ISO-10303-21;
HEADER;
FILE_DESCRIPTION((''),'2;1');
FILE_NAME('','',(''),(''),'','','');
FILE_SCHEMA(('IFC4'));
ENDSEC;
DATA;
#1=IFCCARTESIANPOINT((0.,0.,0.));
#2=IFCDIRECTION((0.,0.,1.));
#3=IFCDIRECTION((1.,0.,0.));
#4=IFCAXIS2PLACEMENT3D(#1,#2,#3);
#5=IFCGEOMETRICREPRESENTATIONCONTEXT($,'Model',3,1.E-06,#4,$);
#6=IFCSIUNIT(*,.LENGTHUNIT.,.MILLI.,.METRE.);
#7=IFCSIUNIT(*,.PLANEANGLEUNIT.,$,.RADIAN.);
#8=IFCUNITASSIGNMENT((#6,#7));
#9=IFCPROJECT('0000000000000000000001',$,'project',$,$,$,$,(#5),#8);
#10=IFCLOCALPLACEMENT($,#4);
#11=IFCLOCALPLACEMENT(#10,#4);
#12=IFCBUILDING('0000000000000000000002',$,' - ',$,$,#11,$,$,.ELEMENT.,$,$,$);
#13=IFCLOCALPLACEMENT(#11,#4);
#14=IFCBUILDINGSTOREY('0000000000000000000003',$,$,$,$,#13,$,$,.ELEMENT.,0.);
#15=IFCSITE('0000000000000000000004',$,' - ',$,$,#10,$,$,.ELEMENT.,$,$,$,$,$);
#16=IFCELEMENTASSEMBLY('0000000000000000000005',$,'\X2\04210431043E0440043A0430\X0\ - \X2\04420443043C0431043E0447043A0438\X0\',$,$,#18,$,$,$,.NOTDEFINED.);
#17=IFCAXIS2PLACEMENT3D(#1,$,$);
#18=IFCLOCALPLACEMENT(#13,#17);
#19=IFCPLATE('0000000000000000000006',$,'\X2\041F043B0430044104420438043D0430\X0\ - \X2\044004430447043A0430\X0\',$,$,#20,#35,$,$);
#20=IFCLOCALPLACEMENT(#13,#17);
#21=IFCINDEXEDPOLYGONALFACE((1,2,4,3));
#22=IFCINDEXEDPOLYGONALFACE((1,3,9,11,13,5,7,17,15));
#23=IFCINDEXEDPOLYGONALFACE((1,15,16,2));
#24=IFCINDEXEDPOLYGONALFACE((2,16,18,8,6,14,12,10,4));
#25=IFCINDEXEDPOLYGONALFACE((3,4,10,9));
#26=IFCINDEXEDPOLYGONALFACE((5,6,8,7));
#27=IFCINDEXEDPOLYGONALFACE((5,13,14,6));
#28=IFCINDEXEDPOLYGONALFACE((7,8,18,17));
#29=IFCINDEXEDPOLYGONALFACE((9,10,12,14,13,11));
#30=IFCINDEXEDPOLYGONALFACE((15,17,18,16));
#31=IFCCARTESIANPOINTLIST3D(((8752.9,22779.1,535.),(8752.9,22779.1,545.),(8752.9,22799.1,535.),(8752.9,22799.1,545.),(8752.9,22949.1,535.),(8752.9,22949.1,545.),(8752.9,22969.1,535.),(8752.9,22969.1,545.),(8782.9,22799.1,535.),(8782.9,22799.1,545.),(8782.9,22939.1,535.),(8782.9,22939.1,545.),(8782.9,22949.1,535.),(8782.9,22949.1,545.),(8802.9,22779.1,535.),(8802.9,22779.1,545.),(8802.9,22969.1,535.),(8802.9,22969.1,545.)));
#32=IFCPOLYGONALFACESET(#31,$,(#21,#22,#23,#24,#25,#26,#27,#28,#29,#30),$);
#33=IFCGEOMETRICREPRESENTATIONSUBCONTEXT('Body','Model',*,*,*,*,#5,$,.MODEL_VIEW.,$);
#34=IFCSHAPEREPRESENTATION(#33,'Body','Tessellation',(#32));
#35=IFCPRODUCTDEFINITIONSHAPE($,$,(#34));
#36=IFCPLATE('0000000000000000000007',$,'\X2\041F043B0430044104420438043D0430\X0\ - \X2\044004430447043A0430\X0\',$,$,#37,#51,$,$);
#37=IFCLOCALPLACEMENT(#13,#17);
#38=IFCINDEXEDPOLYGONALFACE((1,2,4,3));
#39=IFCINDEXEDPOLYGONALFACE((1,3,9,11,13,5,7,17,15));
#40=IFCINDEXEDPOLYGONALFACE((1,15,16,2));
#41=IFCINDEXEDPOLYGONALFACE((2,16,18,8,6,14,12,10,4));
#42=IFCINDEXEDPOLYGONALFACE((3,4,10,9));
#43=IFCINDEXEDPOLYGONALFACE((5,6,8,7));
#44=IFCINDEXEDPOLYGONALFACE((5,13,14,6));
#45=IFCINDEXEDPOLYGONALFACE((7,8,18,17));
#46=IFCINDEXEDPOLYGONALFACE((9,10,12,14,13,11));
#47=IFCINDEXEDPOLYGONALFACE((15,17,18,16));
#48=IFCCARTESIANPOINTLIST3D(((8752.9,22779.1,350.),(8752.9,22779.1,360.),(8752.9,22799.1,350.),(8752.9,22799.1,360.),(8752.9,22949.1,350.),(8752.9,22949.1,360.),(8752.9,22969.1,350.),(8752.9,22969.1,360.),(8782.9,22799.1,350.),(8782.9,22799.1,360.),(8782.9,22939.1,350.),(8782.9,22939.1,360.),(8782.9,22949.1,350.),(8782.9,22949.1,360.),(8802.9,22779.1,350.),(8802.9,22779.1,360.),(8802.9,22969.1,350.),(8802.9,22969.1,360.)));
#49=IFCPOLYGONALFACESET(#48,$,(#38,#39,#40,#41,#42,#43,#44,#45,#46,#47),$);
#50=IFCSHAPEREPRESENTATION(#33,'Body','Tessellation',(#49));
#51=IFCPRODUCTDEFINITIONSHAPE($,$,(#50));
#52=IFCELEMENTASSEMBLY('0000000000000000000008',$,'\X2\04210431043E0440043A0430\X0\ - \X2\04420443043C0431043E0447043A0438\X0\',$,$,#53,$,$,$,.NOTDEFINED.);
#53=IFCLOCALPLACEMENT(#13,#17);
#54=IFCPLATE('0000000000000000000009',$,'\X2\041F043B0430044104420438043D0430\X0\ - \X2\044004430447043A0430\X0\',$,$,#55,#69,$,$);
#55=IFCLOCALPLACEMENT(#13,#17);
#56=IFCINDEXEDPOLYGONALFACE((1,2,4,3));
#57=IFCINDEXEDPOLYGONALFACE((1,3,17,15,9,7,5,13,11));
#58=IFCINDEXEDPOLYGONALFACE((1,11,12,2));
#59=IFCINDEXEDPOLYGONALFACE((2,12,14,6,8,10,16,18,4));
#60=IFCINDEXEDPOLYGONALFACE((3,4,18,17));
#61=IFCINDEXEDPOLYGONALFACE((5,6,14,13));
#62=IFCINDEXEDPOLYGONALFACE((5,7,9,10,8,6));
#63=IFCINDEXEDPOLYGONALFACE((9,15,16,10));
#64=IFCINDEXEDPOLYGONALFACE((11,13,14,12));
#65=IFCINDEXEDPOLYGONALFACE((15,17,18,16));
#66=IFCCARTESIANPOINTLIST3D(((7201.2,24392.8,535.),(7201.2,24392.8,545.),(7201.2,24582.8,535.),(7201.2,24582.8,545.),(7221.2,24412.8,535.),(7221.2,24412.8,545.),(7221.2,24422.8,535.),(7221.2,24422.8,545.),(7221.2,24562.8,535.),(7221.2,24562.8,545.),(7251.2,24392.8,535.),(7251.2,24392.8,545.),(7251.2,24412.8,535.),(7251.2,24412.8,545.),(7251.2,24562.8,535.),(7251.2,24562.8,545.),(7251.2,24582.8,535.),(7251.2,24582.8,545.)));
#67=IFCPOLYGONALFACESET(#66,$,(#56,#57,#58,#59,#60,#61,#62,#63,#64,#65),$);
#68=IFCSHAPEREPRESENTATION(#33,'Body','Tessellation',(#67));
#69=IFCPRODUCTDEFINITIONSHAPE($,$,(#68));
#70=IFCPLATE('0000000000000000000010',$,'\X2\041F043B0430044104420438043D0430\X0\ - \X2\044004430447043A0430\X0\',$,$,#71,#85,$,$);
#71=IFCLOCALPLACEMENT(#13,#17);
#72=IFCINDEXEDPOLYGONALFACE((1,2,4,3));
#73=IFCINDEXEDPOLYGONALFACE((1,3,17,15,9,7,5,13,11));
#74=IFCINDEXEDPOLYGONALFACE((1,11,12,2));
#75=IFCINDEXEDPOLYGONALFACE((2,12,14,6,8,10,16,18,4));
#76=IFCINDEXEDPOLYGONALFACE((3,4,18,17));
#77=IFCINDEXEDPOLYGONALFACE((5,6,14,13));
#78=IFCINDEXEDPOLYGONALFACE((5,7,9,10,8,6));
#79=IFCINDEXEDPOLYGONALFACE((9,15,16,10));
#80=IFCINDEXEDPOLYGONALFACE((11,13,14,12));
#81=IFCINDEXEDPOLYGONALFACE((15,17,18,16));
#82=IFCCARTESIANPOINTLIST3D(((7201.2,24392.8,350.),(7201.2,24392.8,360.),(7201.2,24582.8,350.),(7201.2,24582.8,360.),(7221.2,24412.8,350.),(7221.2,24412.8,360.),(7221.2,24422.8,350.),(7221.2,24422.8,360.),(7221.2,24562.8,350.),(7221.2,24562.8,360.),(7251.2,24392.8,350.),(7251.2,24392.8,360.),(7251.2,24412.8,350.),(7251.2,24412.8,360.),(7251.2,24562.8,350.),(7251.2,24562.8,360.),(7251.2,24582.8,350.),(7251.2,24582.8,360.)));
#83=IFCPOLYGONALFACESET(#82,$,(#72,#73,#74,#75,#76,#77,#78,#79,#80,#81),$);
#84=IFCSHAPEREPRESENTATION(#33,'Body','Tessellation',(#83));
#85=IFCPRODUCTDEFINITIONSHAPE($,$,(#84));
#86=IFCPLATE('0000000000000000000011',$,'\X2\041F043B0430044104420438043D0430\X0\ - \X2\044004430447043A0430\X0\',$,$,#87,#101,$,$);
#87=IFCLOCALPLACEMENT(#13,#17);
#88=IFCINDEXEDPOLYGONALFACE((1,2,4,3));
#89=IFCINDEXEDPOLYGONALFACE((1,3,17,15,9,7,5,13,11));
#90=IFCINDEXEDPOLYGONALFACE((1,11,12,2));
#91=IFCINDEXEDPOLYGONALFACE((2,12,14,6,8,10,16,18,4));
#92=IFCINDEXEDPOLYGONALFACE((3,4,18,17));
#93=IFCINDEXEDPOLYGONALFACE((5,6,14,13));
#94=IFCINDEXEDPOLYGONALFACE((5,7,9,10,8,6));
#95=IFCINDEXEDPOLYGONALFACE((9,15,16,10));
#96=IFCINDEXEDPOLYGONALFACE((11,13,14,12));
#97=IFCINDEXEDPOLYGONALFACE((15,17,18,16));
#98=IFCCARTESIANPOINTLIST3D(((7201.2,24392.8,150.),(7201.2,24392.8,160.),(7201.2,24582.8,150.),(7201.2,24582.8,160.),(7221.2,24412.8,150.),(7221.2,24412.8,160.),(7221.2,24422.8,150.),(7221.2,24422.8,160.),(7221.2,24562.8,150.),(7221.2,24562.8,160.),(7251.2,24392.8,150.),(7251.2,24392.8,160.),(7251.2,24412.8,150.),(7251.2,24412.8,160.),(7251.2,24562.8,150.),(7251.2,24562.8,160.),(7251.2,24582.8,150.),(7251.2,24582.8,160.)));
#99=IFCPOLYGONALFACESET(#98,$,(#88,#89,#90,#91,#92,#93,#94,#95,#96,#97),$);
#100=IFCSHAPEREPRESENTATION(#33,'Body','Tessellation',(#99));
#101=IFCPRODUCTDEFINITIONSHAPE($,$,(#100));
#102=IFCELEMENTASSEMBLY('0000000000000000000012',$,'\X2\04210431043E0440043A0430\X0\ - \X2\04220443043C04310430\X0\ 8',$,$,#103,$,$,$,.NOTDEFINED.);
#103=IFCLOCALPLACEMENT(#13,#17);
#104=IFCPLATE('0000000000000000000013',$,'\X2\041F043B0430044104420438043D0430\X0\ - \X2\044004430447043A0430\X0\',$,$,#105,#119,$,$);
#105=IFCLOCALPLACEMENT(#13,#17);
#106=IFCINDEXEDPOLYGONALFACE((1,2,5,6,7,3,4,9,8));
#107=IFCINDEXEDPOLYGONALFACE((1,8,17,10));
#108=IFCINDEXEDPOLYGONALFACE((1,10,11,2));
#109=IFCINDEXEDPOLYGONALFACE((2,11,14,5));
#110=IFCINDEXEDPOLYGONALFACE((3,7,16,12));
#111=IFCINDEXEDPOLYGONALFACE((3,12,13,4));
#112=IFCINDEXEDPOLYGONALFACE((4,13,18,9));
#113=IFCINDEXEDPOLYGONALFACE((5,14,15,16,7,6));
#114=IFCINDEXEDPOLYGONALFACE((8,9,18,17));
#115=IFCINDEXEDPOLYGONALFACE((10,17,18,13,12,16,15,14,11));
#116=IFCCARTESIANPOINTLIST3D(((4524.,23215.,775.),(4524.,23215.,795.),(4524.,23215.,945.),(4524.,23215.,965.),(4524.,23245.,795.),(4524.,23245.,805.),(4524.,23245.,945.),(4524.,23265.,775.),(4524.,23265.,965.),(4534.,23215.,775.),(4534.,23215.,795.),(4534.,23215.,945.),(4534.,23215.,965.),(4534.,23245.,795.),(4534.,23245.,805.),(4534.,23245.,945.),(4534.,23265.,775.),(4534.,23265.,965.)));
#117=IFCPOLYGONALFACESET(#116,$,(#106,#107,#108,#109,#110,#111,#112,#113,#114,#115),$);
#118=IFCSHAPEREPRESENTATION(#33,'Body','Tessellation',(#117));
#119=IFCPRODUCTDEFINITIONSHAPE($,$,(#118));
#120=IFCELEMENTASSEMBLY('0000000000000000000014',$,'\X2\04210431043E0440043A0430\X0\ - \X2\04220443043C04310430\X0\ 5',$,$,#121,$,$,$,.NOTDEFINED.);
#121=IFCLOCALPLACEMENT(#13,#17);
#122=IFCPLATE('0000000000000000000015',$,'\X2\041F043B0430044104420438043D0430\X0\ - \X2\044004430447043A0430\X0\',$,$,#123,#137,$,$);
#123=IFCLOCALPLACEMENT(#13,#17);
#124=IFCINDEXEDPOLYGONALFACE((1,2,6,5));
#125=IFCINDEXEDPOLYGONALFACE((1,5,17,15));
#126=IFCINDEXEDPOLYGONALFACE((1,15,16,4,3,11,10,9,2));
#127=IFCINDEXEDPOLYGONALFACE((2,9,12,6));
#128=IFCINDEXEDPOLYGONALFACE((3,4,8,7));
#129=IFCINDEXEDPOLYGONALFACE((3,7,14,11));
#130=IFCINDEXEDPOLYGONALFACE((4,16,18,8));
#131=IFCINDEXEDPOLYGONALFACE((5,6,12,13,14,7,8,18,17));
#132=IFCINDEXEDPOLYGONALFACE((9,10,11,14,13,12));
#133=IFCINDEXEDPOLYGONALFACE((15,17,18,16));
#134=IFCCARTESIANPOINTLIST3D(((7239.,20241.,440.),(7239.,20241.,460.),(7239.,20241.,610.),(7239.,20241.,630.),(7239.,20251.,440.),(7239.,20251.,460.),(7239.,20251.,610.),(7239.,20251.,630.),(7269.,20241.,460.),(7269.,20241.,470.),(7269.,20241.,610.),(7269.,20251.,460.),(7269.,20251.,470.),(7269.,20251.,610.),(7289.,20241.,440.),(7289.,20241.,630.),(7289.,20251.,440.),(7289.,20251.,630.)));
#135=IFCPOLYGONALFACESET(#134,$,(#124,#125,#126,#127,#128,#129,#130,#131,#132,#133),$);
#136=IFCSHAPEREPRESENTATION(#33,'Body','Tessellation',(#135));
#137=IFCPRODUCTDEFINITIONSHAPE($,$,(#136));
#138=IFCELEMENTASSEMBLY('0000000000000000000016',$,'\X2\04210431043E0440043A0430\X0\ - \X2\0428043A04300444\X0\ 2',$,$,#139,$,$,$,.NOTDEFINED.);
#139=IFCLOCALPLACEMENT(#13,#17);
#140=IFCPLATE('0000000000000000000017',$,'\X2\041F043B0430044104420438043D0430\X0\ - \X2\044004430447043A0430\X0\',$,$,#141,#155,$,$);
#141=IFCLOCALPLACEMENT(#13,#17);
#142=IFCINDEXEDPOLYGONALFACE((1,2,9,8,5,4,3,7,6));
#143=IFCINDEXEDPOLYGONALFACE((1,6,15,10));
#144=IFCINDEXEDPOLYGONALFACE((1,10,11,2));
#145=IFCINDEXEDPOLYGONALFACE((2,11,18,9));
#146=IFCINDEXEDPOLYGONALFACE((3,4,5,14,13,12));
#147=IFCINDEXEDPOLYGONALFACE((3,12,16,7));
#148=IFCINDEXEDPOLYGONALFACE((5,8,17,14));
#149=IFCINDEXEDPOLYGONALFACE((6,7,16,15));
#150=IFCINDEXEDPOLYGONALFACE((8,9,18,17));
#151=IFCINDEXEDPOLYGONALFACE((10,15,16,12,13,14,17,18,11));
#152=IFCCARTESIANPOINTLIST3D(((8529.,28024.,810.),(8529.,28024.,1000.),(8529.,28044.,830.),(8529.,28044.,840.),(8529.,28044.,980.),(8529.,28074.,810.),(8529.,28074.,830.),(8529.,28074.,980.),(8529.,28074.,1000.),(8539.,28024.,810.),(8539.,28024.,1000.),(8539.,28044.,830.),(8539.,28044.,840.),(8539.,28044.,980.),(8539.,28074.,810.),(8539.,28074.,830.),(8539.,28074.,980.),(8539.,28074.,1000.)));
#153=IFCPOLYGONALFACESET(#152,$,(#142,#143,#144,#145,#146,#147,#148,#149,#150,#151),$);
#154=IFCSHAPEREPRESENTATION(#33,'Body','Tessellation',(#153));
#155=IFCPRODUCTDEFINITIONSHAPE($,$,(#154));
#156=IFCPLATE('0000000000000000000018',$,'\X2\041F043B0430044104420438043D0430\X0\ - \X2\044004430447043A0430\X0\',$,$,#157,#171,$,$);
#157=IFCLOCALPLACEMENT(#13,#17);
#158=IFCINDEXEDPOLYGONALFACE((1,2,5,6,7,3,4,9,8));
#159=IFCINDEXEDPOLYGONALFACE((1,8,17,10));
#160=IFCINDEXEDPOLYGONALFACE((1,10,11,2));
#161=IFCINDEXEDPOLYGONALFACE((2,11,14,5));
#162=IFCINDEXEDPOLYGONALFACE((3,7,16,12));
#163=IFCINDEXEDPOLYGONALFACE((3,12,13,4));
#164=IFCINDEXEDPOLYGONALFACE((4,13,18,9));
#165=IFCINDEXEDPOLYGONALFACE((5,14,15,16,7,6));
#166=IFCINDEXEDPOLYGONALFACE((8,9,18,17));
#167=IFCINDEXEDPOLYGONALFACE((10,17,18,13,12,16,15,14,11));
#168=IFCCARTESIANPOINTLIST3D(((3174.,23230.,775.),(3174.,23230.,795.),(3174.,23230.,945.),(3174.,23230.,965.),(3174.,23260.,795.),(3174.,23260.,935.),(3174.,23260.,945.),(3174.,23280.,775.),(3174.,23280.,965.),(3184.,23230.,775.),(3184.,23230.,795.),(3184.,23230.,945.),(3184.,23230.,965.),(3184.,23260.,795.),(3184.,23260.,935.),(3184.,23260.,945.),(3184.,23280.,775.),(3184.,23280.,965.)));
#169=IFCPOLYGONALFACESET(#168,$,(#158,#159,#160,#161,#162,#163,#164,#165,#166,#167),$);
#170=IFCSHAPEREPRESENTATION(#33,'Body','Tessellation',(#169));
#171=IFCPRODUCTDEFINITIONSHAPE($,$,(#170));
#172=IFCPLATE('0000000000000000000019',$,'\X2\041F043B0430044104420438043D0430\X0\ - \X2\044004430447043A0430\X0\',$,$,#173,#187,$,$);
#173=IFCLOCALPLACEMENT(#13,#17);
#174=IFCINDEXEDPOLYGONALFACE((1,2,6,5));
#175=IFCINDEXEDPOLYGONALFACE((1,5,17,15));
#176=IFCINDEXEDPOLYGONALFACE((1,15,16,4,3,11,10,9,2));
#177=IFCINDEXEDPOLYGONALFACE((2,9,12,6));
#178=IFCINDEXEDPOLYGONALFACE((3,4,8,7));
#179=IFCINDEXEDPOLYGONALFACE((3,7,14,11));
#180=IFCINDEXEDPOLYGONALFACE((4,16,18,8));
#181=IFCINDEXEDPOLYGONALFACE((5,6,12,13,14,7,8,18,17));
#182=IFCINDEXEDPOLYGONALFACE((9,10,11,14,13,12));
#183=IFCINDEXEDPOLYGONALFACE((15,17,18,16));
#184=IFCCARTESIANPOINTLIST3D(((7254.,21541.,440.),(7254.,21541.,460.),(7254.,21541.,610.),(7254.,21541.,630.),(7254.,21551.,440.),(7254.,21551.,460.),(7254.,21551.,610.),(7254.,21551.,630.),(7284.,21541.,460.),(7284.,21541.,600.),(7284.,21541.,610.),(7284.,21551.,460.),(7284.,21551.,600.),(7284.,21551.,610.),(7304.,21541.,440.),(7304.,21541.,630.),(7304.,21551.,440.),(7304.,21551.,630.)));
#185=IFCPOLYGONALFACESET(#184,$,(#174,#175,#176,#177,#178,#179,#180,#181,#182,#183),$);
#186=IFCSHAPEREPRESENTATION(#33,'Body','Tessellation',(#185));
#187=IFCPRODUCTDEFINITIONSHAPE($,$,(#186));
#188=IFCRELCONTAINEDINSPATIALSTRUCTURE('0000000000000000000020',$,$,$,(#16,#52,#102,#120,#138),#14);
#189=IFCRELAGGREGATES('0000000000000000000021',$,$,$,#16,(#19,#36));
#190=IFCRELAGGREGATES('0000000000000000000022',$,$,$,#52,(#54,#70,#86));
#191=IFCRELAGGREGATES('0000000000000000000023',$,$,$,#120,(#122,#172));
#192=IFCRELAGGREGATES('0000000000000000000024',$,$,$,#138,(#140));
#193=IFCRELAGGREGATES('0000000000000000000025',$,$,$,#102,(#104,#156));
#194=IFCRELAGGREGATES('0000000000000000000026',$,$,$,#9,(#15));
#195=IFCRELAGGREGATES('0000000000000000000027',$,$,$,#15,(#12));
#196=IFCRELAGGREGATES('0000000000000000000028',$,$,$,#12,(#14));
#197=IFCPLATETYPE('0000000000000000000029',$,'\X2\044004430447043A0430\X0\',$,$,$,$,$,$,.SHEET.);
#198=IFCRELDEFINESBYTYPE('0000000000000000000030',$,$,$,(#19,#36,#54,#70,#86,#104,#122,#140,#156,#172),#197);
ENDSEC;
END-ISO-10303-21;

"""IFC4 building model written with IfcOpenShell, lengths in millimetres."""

from ifc_helpers import new_model, si_unit, frame, origin_with_axes, place, context, subcontext, project, spatial, line, indexed_curve, outline, extrude, source, transform, mapped, type_object, element, aggregate, save


model = new_model("IFC4")

# Units and contexts
model_context = context("Model", 3, precision=1e-06, world=origin_with_axes())
body_context = subcontext(model_context, "Body", "Model", "MODEL_VIEW")
ifc_project = project(units=[si_unit("LENGTHUNIT", "METRE", prefix="MILLI"), si_unit("PLANEANGLEUNIT", "RADIAN")], contexts=[model_context])

# Site, building, storey
site_placement = place(None, origin_with_axes())
site = spatial("IfcSite", under=ifc_project, at=site_placement, Name=" - ", CompositionType="ELEMENT")
building_placement = place(site_placement, origin_with_axes())
building = spatial("IfcBuilding", under=site, at=building_placement, Name=" - ", CompositionType="ELEMENT")
storey_placement = place(building_placement, origin_with_axes())
storey = spatial("IfcBuildingStorey", under=building, at=storey_placement, CompositionType="ELEMENT", Elevation=0.0)

# Element assemblies, plates
plate_type_1 = type_object("IfcPlateType", Name="ручка", PredefinedType="SHEET")
shared_shape_1 = source(origin_with_axes(), body_context, "Body", "SweptSolid", [
    extrude(outline(indexed_curve([(-95.0, -25.0), (-75.0, -25.0), (-75.0, 5.0), (-65.0, 5.0), (75.0, 5.0), (75.0, -25.0), (95.0, -25.0), (95.0, 25.0), (-95.0, 25.0)], segments=[line(1, 2), line(2, 3), line(3, 4), line(4, 5), line(5, 6), line(6, 7), line(7, 8), line(8, 9), line(9, 1)])), origin_with_axes(), (0.0, 0.0, 1.0), 10.0),
])
assembly_1_placement = place(storey_placement, frame((8752.9, 22674.1, 0.0), z_axis=(0.0, 0.0, 1.0), x_axis=(0.0, 1.0, 0.0)))
assembly_1 = element("IfcElementAssembly", 1, at=assembly_1_placement, inside=storey, Name="Сборка - тумбочки", PredefinedType="NOTDEFINED")
plate_1_placement = place(assembly_1_placement, frame((200.0, -25.0, 535.0), z_axis=(0.0, 0.0, 1.0), x_axis=(-1.0, 0.0, 0.0)))
plate_1 = element("IfcPlate", 2, at=plate_1_placement, type_object=plate_type_1, Name="Пластина - ручка", context=body_context, shape_type="MappedRepresentation", body=[
    mapped(shared_shape_1, transform((0.0, 0.0, 0.0), x_axis=(1.0, 0.0, 0.0), y_axis=(0.0, 1.0, 0.0), z_axis=(0.0, 0.0, 1.0), scale=1.0)),
])
plate_2_placement = place(assembly_1_placement, frame((200.0, -25.0, 350.0), z_axis=(0.0, 0.0, 1.0), x_axis=(-1.0, 0.0, 0.0)))
plate_2 = element("IfcPlate", 3, at=plate_2_placement, type_object=plate_type_1, Name="Пластина - ручка", context=body_context, shape_type="MappedRepresentation", body=[
    mapped(shared_shape_1, transform((0.0, 0.0, 0.0), x_axis=(1.0, 0.0, 0.0), y_axis=(0.0, 1.0, 0.0), z_axis=(0.0, 0.0, 1.0), scale=1.0)),
])
aggregate(assembly_1, [plate_1, plate_2])
assembly_2_placement = place(storey_placement, frame((7251.2, 24687.8, 0.0), z_axis=(0.0, 0.0, 1.0), x_axis=(0.0, -1.0, 0.0)))
assembly_2 = element("IfcElementAssembly", 4, at=assembly_2_placement, inside=storey, Name="Сборка - тумбочки", PredefinedType="NOTDEFINED")
plate_3_placement = place(assembly_2_placement, frame((200.0, -25.0, 535.0), z_axis=(0.0, 0.0, 1.0), x_axis=(-1.0, 0.0, 0.0)))
plate_3 = element("IfcPlate", 5, at=plate_3_placement, type_object=plate_type_1, Name="Пластина - ручка", context=body_context, shape_type="MappedRepresentation", body=[
    mapped(shared_shape_1, transform((0.0, 0.0, 0.0), x_axis=(1.0, 0.0, 0.0), y_axis=(0.0, 1.0, 0.0), z_axis=(0.0, 0.0, 1.0), scale=1.0)),
])
plate_4_placement = place(assembly_2_placement, frame((200.0, -25.0, 350.0), z_axis=(0.0, 0.0, 1.0), x_axis=(-1.0, 0.0, 0.0)))
plate_4 = element("IfcPlate", 6, at=plate_4_placement, type_object=plate_type_1, Name="Пластина - ручка", context=body_context, shape_type="MappedRepresentation", body=[
    mapped(shared_shape_1, transform((0.0, 0.0, 0.0), x_axis=(1.0, 0.0, 0.0), y_axis=(0.0, 1.0, 0.0), z_axis=(0.0, 0.0, 1.0), scale=1.0)),
])
plate_5_placement = place(assembly_2_placement, frame((200.0, -25.0, 150.0), z_axis=(0.0, 0.0, 1.0), x_axis=(-1.0, 0.0, 0.0)))
plate_5 = element("IfcPlate", 7, at=plate_5_placement, type_object=plate_type_1, Name="Пластина - ручка", context=body_context, shape_type="MappedRepresentation", body=[
    mapped(shared_shape_1, transform((0.0, 0.0, 0.0), x_axis=(1.0, 0.0, 0.0), y_axis=(0.0, 1.0, 0.0), z_axis=(0.0, 0.0, 1.0), scale=1.0)),
])
aggregate(assembly_2, [plate_3, plate_4, plate_5])

# Element assemblies, plates
shared_shape_2 = source(origin_with_axes(), body_context, "Body", "SweptSolid", [
    extrude(outline(indexed_curve([(-95.0, -25.0), (-75.0, -25.0), (-75.0, 5.0), (-65.0, 5.0), (75.0, 5.0), (75.0, -25.0), (95.0, -25.0), (95.0, 25.0), (-95.0, 25.0)], segments=[line(1, 2), line(2, 3), line(3, 4), line(4, 5), line(5, 6), line(6, 7), line(7, 8), line(8, 9), line(9, 1)])), origin_with_axes(), (0.0, 0.0, 1.0), 10.0),
])
assembly_3_placement = place(storey_placement, frame((3854.0, 23030.0, 0.0), z_axis=(0.0, 0.0, 1.0), x_axis=(-1.0, 0.0, 0.0)))
assembly_3 = element("IfcElementAssembly", 8, at=assembly_3_placement, inside=storey, Name="Сборка - Тумба 8", PredefinedType="NOTDEFINED")
plate_6_placement = place(assembly_3_placement, frame((-680.0, -210.0, 870.0), z_axis=(1.0, 0.0, 0.0), x_axis=(0.0, 0.0, 1.0)))
plate_6 = element("IfcPlate", 9, at=plate_6_placement, type_object=plate_type_1, Name="Пластина - ручка", context=body_context, shape_type="MappedRepresentation", body=[
    mapped(shared_shape_2, transform((0.0, 0.0, 0.0), x_axis=(1.0, 0.0, 0.0), y_axis=(0.0, 1.0, 0.0), z_axis=(0.0, 0.0, 1.0), scale=1.0)),
])
assembly_4_placement = place(storey_placement, frame((7054.0, 20921.0, 0.0), z_axis=(0.0, 0.0, 1.0), x_axis=(0.0, 1.0, 0.0)))
assembly_4 = element("IfcElementAssembly", 10, at=assembly_4_placement, inside=storey, Name="Сборка - Тумба 5", PredefinedType="NOTDEFINED")
plate_7_placement = place(assembly_4_placement, frame((-680.0, -210.0, 535.0), z_axis=(1.0, 0.0, 0.0), x_axis=(0.0, 0.0, 1.0)))
plate_7 = element("IfcPlate", 11, at=plate_7_placement, type_object=plate_type_1, Name="Пластина - ручка", context=body_context, shape_type="MappedRepresentation", body=[
    mapped(shared_shape_2, transform((0.0, 0.0, 0.0), x_axis=(1.0, 0.0, 0.0), y_axis=(0.0, 1.0, 0.0), z_axis=(0.0, 0.0, 1.0), scale=1.0)),
])
assembly_5_placement = place(storey_placement, frame((7899.0, 28074.0, 0.0), z_axis=(0.0, 0.0, 1.0), x_axis=(1.0, 0.0, 0.0)))
assembly_5 = element("IfcElementAssembly", 12, at=assembly_5_placement, inside=storey, Name="Сборка - Шкаф 2", PredefinedType="NOTDEFINED")
plate_8_placement = place(assembly_5_placement, frame((630.0, -25.0, 905.0), z_axis=(1.0, 0.0, 0.0), x_axis=(0.0, 0.0, 1.0)))
plate_8 = element("IfcPlate", 13, at=plate_8_placement, type_object=plate_type_1, Name="Пластина - ручка", context=body_context, shape_type="MappedRepresentation", body=[
    mapped(shared_shape_2, transform((0.0, 0.0, 0.0), x_axis=(1.0, 0.0, 0.0), y_axis=(0.0, 1.0, 0.0), z_axis=(0.0, 0.0, 1.0), scale=1.0)),
])

# Plates
shared_shape_3 = source(origin_with_axes(), body_context, "Body", "SweptSolid", [
    extrude(outline(indexed_curve([(-95.0, -25.0), (-75.0, -25.0), (-75.0, 5.0), (-65.0, 5.0), (75.0, 5.0), (75.0, -25.0), (95.0, -25.0), (95.0, 25.0), (-95.0, 25.0)], segments=[line(1, 2), line(2, 3), line(3, 4), line(4, 5), line(5, 6), line(6, 7), line(7, 8), line(8, 9), line(9, 1)])), origin_with_axes(), (0.0, 0.0, 1.0), 10.0),
])
plate_9_placement = place(assembly_3_placement, frame((680.0, -225.0, 870.0), z_axis=(-1.0, 0.0, 0.0), x_axis=(0.0, 0.0, -1.0)))
plate_9 = element("IfcPlate", 14, at=plate_9_placement, type_object=plate_type_1, Name="Пластина - ручка", context=body_context, shape_type="MappedRepresentation", body=[
    mapped(shared_shape_3, transform((0.0, 0.0, 0.0), x_axis=(1.0, 0.0, 0.0), y_axis=(0.0, 1.0, 0.0), z_axis=(0.0, 0.0, 1.0), scale=1.0)),
])
plate_10_placement = place(assembly_4_placement, frame((630.0, -225.0, 535.0), z_axis=(-1.0, 0.0, 0.0), x_axis=(0.0, 0.0, -1.0)))
plate_10 = element("IfcPlate", 15, at=plate_10_placement, type_object=plate_type_1, Name="Пластина - ручка", context=body_context, shape_type="MappedRepresentation", body=[
    mapped(shared_shape_3, transform((0.0, 0.0, 0.0), x_axis=(1.0, 0.0, 0.0), y_axis=(0.0, 1.0, 0.0), z_axis=(0.0, 0.0, 1.0), scale=1.0)),
])
aggregate(assembly_4, [plate_7, plate_10])
aggregate(assembly_5, [plate_8])
aggregate(assembly_3, [plate_6, plate_9])

save(model, "model.ifc")
